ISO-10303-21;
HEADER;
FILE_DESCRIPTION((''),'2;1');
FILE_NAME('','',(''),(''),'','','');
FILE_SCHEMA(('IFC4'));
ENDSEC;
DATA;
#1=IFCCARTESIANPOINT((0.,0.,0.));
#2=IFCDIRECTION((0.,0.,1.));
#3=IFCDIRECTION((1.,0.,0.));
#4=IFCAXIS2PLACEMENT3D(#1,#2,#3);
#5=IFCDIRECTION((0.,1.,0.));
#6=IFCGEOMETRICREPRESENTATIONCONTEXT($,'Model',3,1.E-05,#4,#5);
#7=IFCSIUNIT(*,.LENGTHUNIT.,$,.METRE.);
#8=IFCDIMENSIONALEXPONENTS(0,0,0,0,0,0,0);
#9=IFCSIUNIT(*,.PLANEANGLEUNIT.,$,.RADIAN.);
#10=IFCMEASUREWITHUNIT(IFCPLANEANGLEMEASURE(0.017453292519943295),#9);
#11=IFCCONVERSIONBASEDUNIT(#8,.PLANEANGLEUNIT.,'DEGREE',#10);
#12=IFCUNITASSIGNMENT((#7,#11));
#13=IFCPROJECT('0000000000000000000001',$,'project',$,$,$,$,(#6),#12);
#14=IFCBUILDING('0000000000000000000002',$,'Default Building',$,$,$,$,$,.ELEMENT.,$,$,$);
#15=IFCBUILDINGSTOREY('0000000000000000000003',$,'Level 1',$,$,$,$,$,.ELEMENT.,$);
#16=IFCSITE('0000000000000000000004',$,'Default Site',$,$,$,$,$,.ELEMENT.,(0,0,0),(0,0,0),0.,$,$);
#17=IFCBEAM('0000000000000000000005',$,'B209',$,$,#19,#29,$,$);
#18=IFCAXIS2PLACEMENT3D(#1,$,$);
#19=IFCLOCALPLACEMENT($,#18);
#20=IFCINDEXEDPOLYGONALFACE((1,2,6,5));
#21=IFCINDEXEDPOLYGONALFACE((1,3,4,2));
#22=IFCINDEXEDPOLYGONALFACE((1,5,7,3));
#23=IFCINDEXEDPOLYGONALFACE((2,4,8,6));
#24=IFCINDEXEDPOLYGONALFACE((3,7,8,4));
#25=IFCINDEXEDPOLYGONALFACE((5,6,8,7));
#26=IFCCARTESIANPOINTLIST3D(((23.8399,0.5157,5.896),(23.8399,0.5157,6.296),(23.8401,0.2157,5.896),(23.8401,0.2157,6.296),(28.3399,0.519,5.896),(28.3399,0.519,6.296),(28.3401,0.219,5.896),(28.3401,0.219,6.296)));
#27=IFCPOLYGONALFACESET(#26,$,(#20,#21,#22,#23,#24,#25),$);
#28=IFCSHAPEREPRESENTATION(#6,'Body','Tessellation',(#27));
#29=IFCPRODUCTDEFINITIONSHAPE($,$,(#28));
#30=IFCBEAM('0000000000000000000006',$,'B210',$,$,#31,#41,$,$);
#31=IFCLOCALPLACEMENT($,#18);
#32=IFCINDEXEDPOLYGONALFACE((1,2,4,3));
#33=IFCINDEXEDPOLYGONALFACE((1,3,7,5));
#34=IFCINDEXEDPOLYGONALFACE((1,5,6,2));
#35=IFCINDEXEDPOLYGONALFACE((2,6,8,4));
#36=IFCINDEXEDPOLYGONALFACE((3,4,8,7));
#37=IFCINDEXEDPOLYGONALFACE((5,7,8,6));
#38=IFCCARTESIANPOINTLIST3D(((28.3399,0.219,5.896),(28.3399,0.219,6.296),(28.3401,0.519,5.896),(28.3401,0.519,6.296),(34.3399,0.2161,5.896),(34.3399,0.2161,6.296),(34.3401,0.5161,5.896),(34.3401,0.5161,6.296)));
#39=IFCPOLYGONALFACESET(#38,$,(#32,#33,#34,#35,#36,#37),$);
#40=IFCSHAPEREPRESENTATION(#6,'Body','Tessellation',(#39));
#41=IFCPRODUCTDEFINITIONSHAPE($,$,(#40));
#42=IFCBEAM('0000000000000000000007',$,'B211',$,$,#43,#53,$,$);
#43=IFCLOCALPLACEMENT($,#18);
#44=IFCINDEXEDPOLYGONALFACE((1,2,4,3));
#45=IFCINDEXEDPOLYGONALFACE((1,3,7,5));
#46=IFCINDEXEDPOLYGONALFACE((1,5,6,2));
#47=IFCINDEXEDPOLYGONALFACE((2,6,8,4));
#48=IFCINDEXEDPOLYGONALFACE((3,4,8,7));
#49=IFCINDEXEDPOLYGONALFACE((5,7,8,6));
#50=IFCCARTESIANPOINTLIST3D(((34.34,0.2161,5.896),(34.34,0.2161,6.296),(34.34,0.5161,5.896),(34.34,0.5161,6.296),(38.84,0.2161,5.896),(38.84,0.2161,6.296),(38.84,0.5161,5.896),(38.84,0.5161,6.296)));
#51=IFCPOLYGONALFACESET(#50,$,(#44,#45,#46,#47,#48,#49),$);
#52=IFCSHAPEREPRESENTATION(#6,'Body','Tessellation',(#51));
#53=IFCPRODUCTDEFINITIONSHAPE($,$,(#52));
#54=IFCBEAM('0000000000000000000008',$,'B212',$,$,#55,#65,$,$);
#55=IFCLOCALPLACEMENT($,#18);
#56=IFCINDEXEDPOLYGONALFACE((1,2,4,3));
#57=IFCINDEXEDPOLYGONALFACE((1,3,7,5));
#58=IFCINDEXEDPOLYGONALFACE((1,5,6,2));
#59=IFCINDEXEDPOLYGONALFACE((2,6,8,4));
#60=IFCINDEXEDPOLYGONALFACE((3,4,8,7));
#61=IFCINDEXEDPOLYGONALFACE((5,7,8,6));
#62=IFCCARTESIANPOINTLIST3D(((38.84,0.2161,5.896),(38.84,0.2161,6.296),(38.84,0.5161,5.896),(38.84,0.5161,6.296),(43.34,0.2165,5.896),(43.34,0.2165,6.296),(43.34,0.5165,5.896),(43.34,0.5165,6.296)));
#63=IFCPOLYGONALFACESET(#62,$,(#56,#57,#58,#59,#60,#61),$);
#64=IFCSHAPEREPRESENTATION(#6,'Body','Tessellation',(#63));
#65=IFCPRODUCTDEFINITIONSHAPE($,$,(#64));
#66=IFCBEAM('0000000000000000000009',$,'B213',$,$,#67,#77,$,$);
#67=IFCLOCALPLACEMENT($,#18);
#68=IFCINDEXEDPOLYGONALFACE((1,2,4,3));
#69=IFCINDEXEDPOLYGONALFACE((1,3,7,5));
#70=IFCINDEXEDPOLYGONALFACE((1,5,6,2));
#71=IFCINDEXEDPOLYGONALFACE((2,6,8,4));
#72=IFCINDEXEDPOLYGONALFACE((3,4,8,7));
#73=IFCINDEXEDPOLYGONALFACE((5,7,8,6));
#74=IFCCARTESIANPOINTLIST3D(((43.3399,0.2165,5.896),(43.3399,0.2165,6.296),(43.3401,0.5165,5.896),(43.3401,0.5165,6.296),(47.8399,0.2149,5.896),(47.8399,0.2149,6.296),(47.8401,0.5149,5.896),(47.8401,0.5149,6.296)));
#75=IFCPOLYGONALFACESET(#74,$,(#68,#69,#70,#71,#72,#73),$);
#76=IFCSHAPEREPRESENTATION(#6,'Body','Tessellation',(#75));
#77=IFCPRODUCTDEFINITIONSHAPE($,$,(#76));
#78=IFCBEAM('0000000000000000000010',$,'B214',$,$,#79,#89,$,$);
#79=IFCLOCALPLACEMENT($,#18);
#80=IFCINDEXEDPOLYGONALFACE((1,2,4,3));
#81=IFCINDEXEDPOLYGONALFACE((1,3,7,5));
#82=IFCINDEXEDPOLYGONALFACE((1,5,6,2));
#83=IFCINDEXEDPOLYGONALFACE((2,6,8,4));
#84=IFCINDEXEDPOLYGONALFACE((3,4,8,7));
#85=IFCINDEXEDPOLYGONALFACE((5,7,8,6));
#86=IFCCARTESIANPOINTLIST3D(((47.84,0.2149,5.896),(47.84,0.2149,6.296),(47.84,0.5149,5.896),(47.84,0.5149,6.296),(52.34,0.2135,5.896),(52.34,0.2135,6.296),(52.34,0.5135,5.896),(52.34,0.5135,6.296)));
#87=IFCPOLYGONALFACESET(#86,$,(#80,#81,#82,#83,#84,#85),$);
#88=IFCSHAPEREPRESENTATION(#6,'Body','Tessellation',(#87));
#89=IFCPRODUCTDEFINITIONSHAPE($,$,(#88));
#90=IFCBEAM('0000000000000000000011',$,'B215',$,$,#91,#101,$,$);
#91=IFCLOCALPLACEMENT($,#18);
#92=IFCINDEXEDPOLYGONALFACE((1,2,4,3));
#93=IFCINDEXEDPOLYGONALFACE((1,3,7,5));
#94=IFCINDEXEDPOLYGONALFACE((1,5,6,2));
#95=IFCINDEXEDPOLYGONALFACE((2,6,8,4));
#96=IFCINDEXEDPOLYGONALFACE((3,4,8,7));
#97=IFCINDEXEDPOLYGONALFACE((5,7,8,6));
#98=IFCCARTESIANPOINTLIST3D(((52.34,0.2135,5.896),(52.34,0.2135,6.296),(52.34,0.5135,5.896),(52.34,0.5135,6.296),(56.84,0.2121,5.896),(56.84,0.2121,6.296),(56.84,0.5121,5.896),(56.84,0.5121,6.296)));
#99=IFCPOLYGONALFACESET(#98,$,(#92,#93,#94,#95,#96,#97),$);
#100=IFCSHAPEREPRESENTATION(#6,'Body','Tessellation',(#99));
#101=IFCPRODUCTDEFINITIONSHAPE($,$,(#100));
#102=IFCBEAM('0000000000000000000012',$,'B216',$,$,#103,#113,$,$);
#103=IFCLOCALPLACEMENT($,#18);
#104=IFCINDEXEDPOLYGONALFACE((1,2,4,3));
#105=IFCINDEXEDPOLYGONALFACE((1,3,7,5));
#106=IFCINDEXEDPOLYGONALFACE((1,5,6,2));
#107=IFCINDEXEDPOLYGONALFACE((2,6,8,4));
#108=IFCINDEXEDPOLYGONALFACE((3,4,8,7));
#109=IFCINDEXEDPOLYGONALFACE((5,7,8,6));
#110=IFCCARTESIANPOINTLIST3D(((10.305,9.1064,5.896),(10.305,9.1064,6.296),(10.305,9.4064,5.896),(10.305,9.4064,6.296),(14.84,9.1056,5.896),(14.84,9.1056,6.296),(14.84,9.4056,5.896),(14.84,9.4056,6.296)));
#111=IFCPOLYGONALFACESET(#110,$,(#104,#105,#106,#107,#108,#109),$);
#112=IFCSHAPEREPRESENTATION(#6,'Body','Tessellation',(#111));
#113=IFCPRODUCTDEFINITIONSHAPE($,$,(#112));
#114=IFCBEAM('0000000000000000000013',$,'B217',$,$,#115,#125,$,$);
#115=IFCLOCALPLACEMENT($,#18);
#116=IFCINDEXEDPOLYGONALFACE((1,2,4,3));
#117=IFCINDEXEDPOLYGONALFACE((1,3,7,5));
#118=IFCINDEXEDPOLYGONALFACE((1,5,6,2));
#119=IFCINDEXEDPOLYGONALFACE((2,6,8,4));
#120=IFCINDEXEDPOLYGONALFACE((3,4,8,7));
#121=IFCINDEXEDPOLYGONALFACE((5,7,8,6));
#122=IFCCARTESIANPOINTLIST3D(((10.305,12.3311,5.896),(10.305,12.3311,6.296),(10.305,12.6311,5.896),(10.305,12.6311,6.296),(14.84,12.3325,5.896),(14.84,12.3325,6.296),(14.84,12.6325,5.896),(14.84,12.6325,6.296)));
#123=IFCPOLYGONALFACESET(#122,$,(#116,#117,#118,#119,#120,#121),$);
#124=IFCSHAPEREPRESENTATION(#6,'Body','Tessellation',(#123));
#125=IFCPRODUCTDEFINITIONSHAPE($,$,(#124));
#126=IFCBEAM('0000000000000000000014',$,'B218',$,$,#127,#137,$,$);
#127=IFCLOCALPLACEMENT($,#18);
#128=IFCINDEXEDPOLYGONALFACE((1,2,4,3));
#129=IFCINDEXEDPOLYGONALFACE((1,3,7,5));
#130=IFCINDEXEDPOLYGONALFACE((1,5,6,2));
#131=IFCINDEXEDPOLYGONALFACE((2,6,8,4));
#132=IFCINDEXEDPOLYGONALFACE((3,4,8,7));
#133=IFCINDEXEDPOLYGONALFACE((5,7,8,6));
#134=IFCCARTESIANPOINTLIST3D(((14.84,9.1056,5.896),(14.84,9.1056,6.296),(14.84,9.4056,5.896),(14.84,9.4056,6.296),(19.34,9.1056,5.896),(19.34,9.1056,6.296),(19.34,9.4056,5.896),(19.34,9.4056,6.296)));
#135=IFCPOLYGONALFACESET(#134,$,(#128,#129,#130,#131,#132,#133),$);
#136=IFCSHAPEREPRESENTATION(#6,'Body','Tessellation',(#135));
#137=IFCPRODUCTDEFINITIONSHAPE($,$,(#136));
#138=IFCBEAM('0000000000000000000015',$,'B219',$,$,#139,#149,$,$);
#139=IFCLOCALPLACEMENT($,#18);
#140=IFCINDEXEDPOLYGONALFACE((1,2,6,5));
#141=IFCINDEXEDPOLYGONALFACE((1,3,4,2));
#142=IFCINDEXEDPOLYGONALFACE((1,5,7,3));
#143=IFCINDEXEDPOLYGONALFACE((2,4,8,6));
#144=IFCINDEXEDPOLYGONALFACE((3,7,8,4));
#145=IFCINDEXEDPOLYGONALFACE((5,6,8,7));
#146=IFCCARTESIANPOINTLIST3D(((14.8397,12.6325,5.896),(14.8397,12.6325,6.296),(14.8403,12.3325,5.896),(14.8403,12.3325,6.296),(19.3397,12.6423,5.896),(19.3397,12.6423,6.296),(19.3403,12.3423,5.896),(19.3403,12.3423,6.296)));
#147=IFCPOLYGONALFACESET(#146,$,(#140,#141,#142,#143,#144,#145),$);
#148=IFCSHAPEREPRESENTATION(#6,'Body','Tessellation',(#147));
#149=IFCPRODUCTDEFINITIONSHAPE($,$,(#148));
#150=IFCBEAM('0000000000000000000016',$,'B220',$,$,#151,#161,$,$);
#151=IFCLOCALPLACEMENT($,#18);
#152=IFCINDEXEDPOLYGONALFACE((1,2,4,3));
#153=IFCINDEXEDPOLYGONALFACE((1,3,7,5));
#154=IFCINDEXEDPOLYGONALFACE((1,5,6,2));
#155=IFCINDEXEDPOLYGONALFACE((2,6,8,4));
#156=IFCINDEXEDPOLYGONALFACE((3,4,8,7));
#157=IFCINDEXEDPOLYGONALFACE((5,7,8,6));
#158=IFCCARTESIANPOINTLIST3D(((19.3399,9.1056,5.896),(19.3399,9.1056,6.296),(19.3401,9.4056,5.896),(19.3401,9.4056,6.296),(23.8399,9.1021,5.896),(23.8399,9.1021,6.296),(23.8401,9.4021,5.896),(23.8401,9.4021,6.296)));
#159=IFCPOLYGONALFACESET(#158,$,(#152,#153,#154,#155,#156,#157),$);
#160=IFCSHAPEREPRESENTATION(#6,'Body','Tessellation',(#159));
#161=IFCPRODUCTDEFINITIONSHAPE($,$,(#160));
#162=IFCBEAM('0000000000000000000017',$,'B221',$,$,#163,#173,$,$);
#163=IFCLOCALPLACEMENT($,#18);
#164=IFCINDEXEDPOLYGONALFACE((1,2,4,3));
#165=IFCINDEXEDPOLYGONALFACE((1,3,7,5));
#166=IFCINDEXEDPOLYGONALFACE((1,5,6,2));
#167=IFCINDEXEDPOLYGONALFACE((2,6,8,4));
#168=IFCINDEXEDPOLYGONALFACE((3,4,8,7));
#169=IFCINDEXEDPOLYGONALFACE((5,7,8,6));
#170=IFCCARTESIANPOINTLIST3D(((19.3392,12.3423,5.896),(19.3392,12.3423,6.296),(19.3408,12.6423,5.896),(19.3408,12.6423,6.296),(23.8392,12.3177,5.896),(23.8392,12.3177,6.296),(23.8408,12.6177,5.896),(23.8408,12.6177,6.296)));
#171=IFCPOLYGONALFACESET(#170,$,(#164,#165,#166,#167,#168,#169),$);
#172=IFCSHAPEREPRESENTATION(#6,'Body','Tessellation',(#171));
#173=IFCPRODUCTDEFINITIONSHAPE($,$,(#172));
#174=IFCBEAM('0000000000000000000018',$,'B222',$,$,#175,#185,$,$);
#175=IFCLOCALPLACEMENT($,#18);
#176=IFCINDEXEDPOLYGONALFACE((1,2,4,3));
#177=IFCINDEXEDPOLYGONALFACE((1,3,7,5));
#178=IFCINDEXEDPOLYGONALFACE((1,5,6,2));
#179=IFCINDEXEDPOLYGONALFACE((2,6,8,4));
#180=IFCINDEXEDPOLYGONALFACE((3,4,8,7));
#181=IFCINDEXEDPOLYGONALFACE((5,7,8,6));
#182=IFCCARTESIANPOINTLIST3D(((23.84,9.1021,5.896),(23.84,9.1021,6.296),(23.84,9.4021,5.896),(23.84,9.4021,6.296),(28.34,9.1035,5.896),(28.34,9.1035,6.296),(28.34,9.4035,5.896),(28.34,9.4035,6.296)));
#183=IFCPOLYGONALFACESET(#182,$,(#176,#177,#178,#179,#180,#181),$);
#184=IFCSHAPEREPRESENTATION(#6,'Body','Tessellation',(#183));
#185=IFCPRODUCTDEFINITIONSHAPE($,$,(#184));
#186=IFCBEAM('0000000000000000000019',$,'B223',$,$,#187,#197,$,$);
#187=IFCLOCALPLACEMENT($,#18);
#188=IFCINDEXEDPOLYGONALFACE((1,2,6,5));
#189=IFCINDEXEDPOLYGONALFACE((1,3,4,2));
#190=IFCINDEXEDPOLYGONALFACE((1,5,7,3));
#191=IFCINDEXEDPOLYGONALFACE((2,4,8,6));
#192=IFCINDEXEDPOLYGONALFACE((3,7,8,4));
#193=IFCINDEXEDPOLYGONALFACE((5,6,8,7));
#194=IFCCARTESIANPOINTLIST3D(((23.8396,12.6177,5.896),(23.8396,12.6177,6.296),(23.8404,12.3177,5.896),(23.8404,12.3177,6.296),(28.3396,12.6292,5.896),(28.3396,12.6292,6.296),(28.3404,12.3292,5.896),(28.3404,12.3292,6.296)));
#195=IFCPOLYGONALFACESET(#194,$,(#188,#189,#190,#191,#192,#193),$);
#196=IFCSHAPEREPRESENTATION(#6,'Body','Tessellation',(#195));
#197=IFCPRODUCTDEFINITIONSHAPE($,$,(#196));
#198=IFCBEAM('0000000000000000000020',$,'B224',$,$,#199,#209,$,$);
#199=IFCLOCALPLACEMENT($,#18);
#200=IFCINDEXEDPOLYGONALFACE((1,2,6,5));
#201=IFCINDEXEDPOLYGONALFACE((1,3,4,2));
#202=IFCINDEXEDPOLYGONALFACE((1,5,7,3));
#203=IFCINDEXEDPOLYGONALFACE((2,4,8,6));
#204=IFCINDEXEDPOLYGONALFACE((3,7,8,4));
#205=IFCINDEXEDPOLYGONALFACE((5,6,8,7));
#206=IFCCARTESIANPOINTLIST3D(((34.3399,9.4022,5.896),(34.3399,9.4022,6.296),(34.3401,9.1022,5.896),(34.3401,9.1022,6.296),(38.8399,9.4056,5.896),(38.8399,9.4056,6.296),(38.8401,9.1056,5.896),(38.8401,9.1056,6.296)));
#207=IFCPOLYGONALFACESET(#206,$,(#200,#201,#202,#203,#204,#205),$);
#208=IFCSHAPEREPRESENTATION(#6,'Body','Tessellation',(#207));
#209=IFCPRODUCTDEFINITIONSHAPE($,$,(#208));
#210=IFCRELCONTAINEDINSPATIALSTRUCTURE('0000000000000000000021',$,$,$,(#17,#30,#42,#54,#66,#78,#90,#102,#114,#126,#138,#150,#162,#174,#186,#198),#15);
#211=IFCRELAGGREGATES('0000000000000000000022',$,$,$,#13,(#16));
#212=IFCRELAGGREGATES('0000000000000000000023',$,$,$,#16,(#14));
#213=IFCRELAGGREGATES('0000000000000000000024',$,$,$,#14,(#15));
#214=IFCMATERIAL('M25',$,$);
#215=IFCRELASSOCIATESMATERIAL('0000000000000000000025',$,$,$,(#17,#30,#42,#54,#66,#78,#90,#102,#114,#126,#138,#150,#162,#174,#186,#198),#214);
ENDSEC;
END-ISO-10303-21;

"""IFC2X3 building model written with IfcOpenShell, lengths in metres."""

from ifc_helpers import new_model, entity, si_unit, converted_unit, direction, frame, frame_2d, origin_with_axes, place, context, project, spatial, rectangle, extrude, material, element, save


model = new_model("IFC2X3")

# Units and contexts
model_context = context("Model", 3, precision=1e-05, world=origin_with_axes(), true_north=direction((0.0, 1.0, 0.0)))
ifc_project = project(units=[si_unit("LENGTHUNIT", "METRE"), converted_unit("PLANEANGLEUNIT", "DEGREE", entity("IfcPlaneAngleMeasure", 0.017453292519943295), si_unit("PLANEANGLEUNIT", "RADIAN"), dimensions=[0, 0, 0, 0, 0, 0, 0])], contexts=[model_context])

# Site, building, storey
site = spatial("IfcSite", under=ifc_project, Name="Default Site", CompositionType="ELEMENT", RefLatitude=(0, 0, 0), RefLongitude=(0, 0, 0), RefElevation=0.0)
building = spatial("IfcBuilding", under=site, Name="Default Building", CompositionType="ELEMENT")
storey = spatial("IfcBuildingStorey", under=building, Name="Level 1", CompositionType="ELEMENT")

# Beams
ifc_material = material(Name="M25")
placement = place(None, origin_with_axes())
element("IfcBeam", 1, at=placement, inside=storey, material=ifc_material, Name="B209", context=model_context, shape_type="SweptSolid", body=[
    extrude(rectangle(XDim=0.3, YDim=0.4, at=frame_2d((0.0, 0.0), x_axis=(0.0, 1.0, 0.0))), frame((23.84, 0.3657, 6.096), z_axis=(1.0, 0.00075, 0.0), x_axis=(0.0, 0.0, -1.0)), (0.0, 0.0, 1.0), 4.5),
])
element("IfcBeam", 2, at=placement, inside=storey, material=ifc_material, Name="B210", context=model_context, shape_type="SweptSolid", body=[
    extrude(rectangle(XDim=0.3, YDim=0.4, at=frame_2d((0.0, 0.0), x_axis=(0.0, 1.0, 0.0))), frame((28.34, 0.369, 6.096), z_axis=(1.0, -0.000487, 0.0), x_axis=(0.0, 0.0, -1.0)), (0.0, 0.0, 1.0), 6.0),
])
element("IfcBeam", 3, at=placement, inside=storey, material=ifc_material, Name="B211", context=model_context, shape_type="SweptSolid", body=[
    extrude(rectangle(XDim=0.3, YDim=0.4, at=frame_2d((0.0, 0.0), x_axis=(0.0, 1.0, 0.0))), frame((34.34, 0.3661, 6.096), z_axis=(1.0, 0.000003, 0.0), x_axis=(0.0, 0.0, -1.0)), (0.0, 0.0, 1.0), 4.5),
])
element("IfcBeam", 4, at=placement, inside=storey, material=ifc_material, Name="B212", context=model_context, shape_type="SweptSolid", body=[
    extrude(rectangle(XDim=0.3, YDim=0.4, at=frame_2d((0.0, 0.0), x_axis=(0.0, 1.0, 0.0))), frame((38.84, 0.3661, 6.096), z_axis=(1.0, 0.000077, 0.0), x_axis=(0.0, 0.0, -1.0)), (0.0, 0.0, 1.0), 4.5),
])
element("IfcBeam", 5, at=placement, inside=storey, material=ifc_material, Name="B213", context=model_context, shape_type="SweptSolid", body=[
    extrude(rectangle(XDim=0.3, YDim=0.4, at=frame_2d((0.0, 0.0), x_axis=(0.0, 1.0, 0.0))), frame((43.34, 0.3665, 6.096), z_axis=(1.0, -0.000358, 0.0), x_axis=(0.0, 0.0, -1.0)), (0.0, 0.0, 1.0), 4.5),
])
element("IfcBeam", 6, at=placement, inside=storey, material=ifc_material, Name="B214", context=model_context, shape_type="SweptSolid", body=[
    extrude(rectangle(XDim=0.3, YDim=0.4, at=frame_2d((0.0, 0.0), x_axis=(0.0, 1.0, 0.0))), frame((47.84, 0.3649, 6.096), z_axis=(1.0, -0.000297, 0.0), x_axis=(0.0, 0.0, -1.0)), (0.0, 0.0, 1.0), 4.5),
])
element("IfcBeam", 7, at=placement, inside=storey, material=ifc_material, Name="B215", context=model_context, shape_type="SweptSolid", body=[
    extrude(rectangle(XDim=0.3, YDim=0.4, at=frame_2d((0.0, 0.0), x_axis=(0.0, 1.0, 0.0))), frame((52.34, 0.3635, 6.096), z_axis=(1.0, -0.000311, 0.0), x_axis=(0.0, 0.0, -1.0)), (0.0, 0.0, 1.0), 4.5),
])
element("IfcBeam", 8, at=placement, inside=storey, material=ifc_material, Name="B216", context=model_context, shape_type="SweptSolid", body=[
    extrude(rectangle(XDim=0.3, YDim=0.4, at=frame_2d((0.0, 0.0), x_axis=(0.0, 1.0, 0.0))), frame((10.305, 9.2564, 6.096), z_axis=(1.0, -0.000182, 0.0), x_axis=(0.0, 0.0, -1.0)), (0.0, 0.0, 1.0), 4.535),
])
element("IfcBeam", 9, at=placement, inside=storey, material=ifc_material, Name="B217", context=model_context, shape_type="SweptSolid", body=[
    extrude(rectangle(XDim=0.3, YDim=0.4, at=frame_2d((0.0, 0.0), x_axis=(0.0, 1.0, 0.0))), frame((10.305, 12.4811, 6.096), z_axis=(1.0, 0.000301, 0.0), x_axis=(0.0, 0.0, -1.0)), (0.0, 0.0, 1.0), 4.535),
])
element("IfcBeam", 10, at=placement, inside=storey, material=ifc_material, Name="B218", context=model_context, shape_type="SweptSolid", body=[
    extrude(rectangle(XDim=0.3, YDim=0.4, at=frame_2d((0.0, 0.0), x_axis=(0.0, 1.0, 0.0))), frame((14.84, 9.2556, 6.096), z_axis=(1.0, 0.000013, 0.0), x_axis=(0.0, 0.0, -1.0)), (0.0, 0.0, 1.0), 4.5),
])
element("IfcBeam", 11, at=placement, inside=storey, material=ifc_material, Name="B219", context=model_context, shape_type="SweptSolid", body=[
    extrude(rectangle(XDim=0.3, YDim=0.4, at=frame_2d((0.0, 0.0), x_axis=(0.0, 1.0, 0.0))), frame((14.84, 12.4825, 6.096), z_axis=(0.999998, 0.002176, 0.0), x_axis=(0.0, 0.0, -1.0)), (0.0, 0.0, 1.0), 4.5),
])
element("IfcBeam", 12, at=placement, inside=storey, material=ifc_material, Name="B220", context=model_context, shape_type="SweptSolid", body=[
    extrude(rectangle(XDim=0.3, YDim=0.4, at=frame_2d((0.0, 0.0), x_axis=(0.0, 1.0, 0.0))), frame((19.34, 9.2556, 6.096), z_axis=(1.0, -0.000779, 0.0), x_axis=(0.0, 0.0, -1.0)), (0.0, 0.0, 1.0), 4.5),
])
element("IfcBeam", 13, at=placement, inside=storey, material=ifc_material, Name="B221", context=model_context, shape_type="SweptSolid", body=[
    extrude(rectangle(XDim=0.3, YDim=0.4, at=frame_2d((0.0, 0.0), x_axis=(0.0, 1.0, 0.0))), frame((19.34, 12.4923, 6.096), z_axis=(0.999985, -0.005463, 0.0), x_axis=(0.0, 0.0, -1.0)), (0.0, 0.0, 1.0), 4.5001),
])
element("IfcBeam", 14, at=placement, inside=storey, material=ifc_material, Name="B222", context=model_context, shape_type="SweptSolid", body=[
    extrude(rectangle(XDim=0.3, YDim=0.4, at=frame_2d((0.0, 0.0), x_axis=(0.0, 1.0, 0.0))), frame((23.84, 9.2521, 6.096), z_axis=(1.0, 0.000307, 0.0), x_axis=(0.0, 0.0, -1.0)), (0.0, 0.0, 1.0), 4.5),
])
element("IfcBeam", 15, at=placement, inside=storey, material=ifc_material, Name="B223", context=model_context, shape_type="SweptSolid", body=[
    extrude(rectangle(XDim=0.3, YDim=0.4, at=frame_2d((0.0, 0.0), x_axis=(0.0, 1.0, 0.0))), frame((23.84, 12.4677, 6.096), z_axis=(0.999997, 0.002551, 0.0), x_axis=(0.0, 0.0, -1.0)), (0.0, 0.0, 1.0), 4.5),
])
element("IfcBeam", 16, at=placement, inside=storey, material=ifc_material, Name="B224", context=model_context, shape_type="SweptSolid", body=[
    extrude(rectangle(XDim=0.3, YDim=0.4, at=frame_2d((0.0, 0.0), x_axis=(0.0, 1.0, 0.0))), frame((34.34, 9.2522, 6.096), z_axis=(1.0, 0.000748, 0.0), x_axis=(0.0, 0.0, -1.0)), (0.0, 0.0, 1.0), 4.5),
])

save(model, "model.ifc")
